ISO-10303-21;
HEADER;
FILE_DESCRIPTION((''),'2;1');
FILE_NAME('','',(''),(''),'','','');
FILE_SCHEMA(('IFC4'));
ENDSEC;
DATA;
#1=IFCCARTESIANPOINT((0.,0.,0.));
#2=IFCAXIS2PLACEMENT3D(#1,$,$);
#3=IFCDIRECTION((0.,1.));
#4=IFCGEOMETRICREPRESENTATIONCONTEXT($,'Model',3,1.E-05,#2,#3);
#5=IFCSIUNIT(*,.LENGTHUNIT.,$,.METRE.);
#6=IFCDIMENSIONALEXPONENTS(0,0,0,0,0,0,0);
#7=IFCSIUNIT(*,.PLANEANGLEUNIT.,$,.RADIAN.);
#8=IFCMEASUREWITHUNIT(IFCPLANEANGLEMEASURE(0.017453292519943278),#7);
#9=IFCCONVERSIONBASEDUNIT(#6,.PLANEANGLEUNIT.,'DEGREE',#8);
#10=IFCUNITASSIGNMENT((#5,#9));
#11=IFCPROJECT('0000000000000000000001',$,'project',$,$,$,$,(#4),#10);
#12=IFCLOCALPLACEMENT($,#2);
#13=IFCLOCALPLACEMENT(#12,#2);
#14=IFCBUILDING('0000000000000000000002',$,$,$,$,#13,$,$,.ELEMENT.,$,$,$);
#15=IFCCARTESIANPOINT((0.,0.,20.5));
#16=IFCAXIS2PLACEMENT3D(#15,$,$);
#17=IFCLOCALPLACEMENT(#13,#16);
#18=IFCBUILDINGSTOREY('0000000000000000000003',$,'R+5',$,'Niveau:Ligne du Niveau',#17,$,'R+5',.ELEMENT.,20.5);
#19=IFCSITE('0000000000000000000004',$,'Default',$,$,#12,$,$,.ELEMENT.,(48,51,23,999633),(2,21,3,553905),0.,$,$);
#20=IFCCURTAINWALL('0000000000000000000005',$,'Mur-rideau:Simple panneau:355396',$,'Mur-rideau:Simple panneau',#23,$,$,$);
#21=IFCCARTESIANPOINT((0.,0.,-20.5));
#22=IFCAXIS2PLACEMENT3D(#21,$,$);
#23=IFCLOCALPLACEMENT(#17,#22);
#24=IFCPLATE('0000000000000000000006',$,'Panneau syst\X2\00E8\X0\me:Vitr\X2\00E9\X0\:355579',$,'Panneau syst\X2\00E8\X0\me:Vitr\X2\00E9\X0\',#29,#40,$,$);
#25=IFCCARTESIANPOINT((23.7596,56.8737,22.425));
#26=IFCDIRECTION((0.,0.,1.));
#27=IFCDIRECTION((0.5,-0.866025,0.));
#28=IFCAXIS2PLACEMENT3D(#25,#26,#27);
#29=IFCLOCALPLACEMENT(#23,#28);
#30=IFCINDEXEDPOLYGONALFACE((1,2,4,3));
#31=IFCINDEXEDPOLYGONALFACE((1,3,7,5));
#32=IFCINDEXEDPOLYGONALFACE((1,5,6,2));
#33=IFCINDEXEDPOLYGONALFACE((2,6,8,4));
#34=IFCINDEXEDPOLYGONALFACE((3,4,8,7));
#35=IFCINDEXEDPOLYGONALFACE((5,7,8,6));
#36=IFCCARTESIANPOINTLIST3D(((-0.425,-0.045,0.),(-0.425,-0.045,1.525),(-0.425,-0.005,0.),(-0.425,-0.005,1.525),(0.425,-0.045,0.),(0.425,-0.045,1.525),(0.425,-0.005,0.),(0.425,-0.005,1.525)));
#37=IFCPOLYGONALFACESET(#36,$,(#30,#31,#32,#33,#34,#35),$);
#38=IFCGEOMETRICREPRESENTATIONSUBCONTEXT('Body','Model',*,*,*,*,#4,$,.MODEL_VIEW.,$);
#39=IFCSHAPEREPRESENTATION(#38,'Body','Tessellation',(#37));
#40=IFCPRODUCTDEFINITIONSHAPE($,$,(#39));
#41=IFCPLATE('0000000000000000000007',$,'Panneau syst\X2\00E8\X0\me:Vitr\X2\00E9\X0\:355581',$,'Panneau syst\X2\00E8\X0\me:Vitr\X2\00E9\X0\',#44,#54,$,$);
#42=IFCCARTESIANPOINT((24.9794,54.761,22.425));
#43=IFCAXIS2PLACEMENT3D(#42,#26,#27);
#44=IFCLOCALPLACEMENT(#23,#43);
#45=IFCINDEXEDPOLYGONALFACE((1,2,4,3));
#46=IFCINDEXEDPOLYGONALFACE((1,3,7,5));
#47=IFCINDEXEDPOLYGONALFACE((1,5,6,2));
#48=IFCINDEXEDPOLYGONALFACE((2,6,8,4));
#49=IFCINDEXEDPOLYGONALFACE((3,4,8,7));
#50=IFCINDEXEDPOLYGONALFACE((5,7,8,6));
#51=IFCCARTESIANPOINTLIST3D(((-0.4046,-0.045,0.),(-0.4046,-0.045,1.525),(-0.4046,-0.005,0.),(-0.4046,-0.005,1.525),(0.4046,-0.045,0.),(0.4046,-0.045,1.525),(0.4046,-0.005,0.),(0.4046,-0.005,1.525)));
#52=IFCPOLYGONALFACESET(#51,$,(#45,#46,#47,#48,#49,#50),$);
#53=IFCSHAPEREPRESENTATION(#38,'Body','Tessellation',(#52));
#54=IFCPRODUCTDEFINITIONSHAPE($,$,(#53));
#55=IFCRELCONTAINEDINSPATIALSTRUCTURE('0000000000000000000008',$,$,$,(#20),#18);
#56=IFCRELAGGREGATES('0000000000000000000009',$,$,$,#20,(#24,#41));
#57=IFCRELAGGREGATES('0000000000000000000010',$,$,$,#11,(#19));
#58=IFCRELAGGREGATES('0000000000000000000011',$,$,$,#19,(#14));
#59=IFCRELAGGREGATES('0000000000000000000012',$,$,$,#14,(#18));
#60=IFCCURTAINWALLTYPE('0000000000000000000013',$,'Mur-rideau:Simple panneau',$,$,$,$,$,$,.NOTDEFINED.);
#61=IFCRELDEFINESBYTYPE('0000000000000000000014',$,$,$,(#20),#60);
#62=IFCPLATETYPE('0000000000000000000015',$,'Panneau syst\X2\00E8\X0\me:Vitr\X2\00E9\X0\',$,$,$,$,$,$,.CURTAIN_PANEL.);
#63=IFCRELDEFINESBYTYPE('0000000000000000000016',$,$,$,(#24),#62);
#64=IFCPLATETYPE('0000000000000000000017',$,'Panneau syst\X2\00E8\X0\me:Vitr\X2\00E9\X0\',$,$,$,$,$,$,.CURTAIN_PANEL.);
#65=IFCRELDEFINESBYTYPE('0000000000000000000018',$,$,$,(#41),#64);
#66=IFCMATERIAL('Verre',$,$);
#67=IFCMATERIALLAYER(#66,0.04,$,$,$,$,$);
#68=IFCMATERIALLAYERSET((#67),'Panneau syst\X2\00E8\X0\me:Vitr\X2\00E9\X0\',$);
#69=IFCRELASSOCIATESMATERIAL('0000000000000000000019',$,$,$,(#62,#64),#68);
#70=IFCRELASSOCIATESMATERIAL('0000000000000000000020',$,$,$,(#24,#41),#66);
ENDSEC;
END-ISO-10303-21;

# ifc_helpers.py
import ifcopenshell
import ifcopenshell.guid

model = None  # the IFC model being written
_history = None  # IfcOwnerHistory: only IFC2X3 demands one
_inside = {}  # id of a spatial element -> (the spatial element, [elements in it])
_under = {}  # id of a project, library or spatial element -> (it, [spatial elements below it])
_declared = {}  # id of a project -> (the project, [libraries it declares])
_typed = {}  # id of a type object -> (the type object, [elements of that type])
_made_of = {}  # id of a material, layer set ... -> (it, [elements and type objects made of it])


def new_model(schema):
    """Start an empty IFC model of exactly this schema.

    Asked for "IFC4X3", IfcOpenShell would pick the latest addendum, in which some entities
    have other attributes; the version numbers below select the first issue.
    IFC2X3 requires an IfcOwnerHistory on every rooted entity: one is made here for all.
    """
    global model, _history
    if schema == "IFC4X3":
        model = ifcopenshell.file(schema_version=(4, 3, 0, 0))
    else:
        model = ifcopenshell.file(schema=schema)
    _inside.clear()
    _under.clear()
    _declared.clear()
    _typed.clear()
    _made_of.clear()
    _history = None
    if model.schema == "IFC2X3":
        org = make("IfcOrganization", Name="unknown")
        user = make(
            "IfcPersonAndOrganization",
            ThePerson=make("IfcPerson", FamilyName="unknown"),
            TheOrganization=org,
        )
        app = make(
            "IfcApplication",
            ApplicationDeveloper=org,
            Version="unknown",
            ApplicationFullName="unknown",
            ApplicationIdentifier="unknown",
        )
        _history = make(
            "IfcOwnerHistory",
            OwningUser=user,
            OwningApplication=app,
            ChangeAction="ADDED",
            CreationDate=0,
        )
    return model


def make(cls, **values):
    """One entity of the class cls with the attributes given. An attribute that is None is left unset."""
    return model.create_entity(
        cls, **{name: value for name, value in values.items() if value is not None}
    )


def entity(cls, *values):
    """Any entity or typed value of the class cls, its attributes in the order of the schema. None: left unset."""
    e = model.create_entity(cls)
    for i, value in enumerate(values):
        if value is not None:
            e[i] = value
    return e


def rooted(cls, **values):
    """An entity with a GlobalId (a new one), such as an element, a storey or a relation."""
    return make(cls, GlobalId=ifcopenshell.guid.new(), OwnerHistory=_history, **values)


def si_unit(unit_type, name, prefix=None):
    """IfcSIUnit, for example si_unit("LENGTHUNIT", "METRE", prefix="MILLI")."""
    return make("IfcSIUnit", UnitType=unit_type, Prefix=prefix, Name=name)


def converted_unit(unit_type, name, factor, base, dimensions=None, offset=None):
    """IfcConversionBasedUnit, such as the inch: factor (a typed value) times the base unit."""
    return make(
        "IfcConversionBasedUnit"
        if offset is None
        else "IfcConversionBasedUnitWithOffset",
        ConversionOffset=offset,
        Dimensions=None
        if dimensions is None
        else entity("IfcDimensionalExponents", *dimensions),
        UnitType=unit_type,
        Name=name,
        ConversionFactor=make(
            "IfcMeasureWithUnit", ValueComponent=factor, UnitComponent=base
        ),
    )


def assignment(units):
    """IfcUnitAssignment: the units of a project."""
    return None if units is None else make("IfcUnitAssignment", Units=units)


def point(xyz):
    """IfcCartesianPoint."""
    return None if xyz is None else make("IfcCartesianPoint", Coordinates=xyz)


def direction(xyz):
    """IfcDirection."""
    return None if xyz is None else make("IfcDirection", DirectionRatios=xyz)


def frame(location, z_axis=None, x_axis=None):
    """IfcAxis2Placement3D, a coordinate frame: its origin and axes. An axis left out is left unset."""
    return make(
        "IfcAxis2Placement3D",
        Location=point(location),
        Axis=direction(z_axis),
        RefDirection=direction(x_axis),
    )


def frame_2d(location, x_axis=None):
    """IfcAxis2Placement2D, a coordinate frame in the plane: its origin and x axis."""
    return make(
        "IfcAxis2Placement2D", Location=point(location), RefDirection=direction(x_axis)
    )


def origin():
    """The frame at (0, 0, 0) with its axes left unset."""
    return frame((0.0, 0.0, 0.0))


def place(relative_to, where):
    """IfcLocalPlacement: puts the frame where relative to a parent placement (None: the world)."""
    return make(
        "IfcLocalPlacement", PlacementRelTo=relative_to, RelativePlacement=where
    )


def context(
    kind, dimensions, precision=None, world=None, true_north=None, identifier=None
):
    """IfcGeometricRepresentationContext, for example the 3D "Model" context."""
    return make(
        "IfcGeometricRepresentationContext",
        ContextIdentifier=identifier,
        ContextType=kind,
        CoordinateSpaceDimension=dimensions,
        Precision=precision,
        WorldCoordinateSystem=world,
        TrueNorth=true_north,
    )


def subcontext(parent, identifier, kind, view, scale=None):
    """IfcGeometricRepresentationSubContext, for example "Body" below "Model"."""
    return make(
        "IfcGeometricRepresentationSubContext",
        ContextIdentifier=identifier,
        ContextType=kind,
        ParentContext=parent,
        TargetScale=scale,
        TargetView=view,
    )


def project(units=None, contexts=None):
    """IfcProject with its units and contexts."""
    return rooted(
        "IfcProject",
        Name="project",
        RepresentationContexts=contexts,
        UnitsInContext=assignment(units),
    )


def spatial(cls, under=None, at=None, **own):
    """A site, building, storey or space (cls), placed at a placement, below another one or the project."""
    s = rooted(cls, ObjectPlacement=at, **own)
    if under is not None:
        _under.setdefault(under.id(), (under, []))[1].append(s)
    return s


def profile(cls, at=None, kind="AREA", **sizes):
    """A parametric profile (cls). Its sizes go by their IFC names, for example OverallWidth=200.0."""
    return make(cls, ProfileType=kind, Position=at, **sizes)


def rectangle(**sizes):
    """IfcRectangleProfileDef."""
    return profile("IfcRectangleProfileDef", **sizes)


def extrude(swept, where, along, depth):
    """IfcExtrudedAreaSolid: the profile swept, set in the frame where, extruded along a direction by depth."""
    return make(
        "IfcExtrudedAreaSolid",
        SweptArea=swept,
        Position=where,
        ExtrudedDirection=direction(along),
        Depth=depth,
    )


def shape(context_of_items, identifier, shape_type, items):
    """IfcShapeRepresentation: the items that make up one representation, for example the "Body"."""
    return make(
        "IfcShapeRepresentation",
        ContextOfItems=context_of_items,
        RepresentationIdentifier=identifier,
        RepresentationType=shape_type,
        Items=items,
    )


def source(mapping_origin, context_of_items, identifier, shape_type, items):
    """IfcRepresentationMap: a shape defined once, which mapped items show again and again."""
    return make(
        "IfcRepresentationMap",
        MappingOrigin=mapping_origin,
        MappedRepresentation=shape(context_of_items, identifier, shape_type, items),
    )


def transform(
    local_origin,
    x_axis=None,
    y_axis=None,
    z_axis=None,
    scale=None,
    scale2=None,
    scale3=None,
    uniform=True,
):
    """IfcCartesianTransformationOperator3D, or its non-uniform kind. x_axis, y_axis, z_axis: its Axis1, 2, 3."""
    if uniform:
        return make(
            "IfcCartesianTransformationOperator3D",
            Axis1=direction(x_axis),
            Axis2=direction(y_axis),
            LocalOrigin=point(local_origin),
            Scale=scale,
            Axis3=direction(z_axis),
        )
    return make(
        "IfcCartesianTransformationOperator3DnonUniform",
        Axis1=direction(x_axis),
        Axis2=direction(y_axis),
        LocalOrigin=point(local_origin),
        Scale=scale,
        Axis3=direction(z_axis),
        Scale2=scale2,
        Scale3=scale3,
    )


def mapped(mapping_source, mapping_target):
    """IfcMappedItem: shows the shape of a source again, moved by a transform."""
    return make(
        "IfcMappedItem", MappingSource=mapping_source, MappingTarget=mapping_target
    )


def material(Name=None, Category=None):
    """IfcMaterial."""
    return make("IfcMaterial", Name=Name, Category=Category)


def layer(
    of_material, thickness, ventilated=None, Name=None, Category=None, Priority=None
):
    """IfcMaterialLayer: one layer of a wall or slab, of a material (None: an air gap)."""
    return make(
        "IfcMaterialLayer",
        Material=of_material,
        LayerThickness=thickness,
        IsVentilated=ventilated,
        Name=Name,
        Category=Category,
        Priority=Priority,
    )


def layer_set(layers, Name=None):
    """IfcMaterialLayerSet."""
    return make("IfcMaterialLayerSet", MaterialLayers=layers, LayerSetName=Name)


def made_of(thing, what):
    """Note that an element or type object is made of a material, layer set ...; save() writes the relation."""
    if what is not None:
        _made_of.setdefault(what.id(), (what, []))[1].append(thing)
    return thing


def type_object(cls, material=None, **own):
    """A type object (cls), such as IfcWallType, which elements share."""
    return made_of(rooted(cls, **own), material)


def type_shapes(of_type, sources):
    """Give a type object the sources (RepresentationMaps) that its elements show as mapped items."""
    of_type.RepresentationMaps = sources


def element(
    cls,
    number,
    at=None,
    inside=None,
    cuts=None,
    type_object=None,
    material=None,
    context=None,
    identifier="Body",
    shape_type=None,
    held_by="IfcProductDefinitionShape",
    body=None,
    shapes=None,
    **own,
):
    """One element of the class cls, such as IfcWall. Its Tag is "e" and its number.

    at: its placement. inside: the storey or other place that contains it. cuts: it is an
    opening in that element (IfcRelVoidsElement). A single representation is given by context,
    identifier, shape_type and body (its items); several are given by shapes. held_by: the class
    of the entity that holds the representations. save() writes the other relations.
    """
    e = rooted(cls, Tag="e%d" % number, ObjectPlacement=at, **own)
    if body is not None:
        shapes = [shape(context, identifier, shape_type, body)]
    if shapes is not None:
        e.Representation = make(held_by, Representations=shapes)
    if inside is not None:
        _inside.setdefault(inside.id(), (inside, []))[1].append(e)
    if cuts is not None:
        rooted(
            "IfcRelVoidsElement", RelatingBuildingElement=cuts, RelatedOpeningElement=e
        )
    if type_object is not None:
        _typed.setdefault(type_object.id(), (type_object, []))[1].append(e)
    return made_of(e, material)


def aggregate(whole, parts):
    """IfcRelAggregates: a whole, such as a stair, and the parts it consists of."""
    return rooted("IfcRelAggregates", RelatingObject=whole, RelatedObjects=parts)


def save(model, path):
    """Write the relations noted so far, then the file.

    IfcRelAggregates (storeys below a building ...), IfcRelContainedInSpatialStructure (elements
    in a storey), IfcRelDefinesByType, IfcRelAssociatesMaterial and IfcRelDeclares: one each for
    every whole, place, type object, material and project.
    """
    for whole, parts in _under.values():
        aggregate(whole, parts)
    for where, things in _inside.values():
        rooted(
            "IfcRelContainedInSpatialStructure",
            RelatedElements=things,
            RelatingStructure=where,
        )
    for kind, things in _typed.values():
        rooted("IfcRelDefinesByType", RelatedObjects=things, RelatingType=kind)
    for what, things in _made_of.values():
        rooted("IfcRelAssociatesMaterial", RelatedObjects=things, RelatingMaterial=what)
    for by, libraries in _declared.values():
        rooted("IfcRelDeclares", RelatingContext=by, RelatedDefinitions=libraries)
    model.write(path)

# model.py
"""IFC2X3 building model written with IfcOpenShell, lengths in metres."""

from ifc_helpers import new_model, entity, si_unit, converted_unit, direction, frame, frame_2d, origin, place, context, subcontext, project, spatial, rectangle, extrude, source, transform, mapped, material, layer, layer_set, type_object, type_shapes, element, aggregate, save


model = new_model("IFC2X3")

# Units and contexts
model_context = context("Model", 3, precision=1e-05, world=origin(), true_north=direction((0.0, 1.0)))
body_context = subcontext(model_context, "Body", "Model", "MODEL_VIEW")
ifc_project = project(units=[si_unit("LENGTHUNIT", "METRE"), converted_unit("PLANEANGLEUNIT", "DEGREE", entity("IfcPlaneAngleMeasure", 0.017453292519943278), si_unit("PLANEANGLEUNIT", "RADIAN"), dimensions=[0, 0, 0, 0, 0, 0, 0])], contexts=[model_context])

# Site, building, storey
site_placement = place(None, origin())
site = spatial("IfcSite", under=ifc_project, at=site_placement, Name="Default", CompositionType="ELEMENT", RefLatitude=(48, 51, 23, 999633), RefLongitude=(2, 21, 3, 553905), RefElevation=0.0)
building_placement = place(site_placement, origin())
building = spatial("IfcBuilding", under=site, at=building_placement, CompositionType="ELEMENT")
storey_placement = place(building_placement, frame((0.0, 0.0, 20.5)))
storey = spatial("IfcBuildingStorey", under=building, at=storey_placement, Name="R+5", ObjectType="Niveau:Ligne du Niveau", LongName="R+5", CompositionType="ELEMENT", Elevation=20.5)

# Curtain wall, plates
curtain_wall_type = type_object("IfcCurtainWallType", Name="Mur-rideau:Simple panneau", PredefinedType="NOTDEFINED")
curtain_wall_placement = place(storey_placement, frame((0.0, 0.0, -20.5)))
curtain_wall = element("IfcCurtainWall", 1, at=curtain_wall_placement, inside=storey, type_object=curtain_wall_type, Name="Mur-rideau:Simple panneau:355396", ObjectType="Mur-rideau:Simple panneau")
ifc_material_1 = material(Name="Verre")
ifc_layer = layer(ifc_material_1, 0.04)
ifc_layer_set = layer_set([ifc_layer], Name="Panneau système:Vitré")
plate_type_1 = type_object("IfcPlateType", Name="Panneau système:Vitré", PredefinedType="CURTAIN_PANEL", material=ifc_layer_set)
shared_shape_1 = source(origin(), body_context, "Body", "SweptSolid", [
    extrude(rectangle(XDim=0.04, YDim=0.85, at=frame_2d((0.0, 0.0), x_axis=(1.0, 0.0))), frame((0.0, -0.025, 0.0), z_axis=(0.0, 0.0, 1.0), x_axis=(0.0, 1.0, 0.0)), (0.0, 0.0, 1.0), 1.525),
])
type_shapes(plate_type_1, [shared_shape_1])
plate_1_placement = place(curtain_wall_placement, frame((23.7596, 56.8737, 22.425), z_axis=(0.0, 0.0, 1.0), x_axis=(0.5, -0.866025, 0.0)))
plate_1 = element("IfcPlate", 2, at=plate_1_placement, type_object=plate_type_1, material=ifc_material_1, Name="Panneau système:Vitré:355579", ObjectType="Panneau système:Vitré", context=body_context, shape_type="MappedRepresentation", body=[
    mapped(shared_shape_1, transform((0.0, 0.0, 0.0), scale=1.0)),
])
plate_type_2 = type_object("IfcPlateType", Name="Panneau système:Vitré", PredefinedType="CURTAIN_PANEL", material=ifc_layer_set)
shared_shape_2 = source(origin(), body_context, "Body", "SweptSolid", [
    extrude(rectangle(XDim=0.04, YDim=0.8091, at=frame_2d((0.0, 0.0), x_axis=(1.0, 0.0))), frame((0.0, -0.025, 0.0), z_axis=(0.0, 0.0, 1.0), x_axis=(0.0, 1.0, 0.0)), (0.0, 0.0, 1.0), 1.525),
])
type_shapes(plate_type_2, [shared_shape_2])
plate_2_placement = place(curtain_wall_placement, frame((24.9794, 54.761, 22.425), z_axis=(0.0, 0.0, 1.0), x_axis=(0.5, -0.866025, 0.0)))
plate_2 = element("IfcPlate", 3, at=plate_2_placement, type_object=plate_type_2, material=ifc_material_1, Name="Panneau système:Vitré:355581", ObjectType="Panneau système:Vitré", context=body_context, shape_type="MappedRepresentation", body=[
    mapped(shared_shape_2, transform((0.0, 0.0, 0.0), scale=1.0)),
])
aggregate(curtain_wall, [plate_1, plate_2])

save(model, "model.ifc")
